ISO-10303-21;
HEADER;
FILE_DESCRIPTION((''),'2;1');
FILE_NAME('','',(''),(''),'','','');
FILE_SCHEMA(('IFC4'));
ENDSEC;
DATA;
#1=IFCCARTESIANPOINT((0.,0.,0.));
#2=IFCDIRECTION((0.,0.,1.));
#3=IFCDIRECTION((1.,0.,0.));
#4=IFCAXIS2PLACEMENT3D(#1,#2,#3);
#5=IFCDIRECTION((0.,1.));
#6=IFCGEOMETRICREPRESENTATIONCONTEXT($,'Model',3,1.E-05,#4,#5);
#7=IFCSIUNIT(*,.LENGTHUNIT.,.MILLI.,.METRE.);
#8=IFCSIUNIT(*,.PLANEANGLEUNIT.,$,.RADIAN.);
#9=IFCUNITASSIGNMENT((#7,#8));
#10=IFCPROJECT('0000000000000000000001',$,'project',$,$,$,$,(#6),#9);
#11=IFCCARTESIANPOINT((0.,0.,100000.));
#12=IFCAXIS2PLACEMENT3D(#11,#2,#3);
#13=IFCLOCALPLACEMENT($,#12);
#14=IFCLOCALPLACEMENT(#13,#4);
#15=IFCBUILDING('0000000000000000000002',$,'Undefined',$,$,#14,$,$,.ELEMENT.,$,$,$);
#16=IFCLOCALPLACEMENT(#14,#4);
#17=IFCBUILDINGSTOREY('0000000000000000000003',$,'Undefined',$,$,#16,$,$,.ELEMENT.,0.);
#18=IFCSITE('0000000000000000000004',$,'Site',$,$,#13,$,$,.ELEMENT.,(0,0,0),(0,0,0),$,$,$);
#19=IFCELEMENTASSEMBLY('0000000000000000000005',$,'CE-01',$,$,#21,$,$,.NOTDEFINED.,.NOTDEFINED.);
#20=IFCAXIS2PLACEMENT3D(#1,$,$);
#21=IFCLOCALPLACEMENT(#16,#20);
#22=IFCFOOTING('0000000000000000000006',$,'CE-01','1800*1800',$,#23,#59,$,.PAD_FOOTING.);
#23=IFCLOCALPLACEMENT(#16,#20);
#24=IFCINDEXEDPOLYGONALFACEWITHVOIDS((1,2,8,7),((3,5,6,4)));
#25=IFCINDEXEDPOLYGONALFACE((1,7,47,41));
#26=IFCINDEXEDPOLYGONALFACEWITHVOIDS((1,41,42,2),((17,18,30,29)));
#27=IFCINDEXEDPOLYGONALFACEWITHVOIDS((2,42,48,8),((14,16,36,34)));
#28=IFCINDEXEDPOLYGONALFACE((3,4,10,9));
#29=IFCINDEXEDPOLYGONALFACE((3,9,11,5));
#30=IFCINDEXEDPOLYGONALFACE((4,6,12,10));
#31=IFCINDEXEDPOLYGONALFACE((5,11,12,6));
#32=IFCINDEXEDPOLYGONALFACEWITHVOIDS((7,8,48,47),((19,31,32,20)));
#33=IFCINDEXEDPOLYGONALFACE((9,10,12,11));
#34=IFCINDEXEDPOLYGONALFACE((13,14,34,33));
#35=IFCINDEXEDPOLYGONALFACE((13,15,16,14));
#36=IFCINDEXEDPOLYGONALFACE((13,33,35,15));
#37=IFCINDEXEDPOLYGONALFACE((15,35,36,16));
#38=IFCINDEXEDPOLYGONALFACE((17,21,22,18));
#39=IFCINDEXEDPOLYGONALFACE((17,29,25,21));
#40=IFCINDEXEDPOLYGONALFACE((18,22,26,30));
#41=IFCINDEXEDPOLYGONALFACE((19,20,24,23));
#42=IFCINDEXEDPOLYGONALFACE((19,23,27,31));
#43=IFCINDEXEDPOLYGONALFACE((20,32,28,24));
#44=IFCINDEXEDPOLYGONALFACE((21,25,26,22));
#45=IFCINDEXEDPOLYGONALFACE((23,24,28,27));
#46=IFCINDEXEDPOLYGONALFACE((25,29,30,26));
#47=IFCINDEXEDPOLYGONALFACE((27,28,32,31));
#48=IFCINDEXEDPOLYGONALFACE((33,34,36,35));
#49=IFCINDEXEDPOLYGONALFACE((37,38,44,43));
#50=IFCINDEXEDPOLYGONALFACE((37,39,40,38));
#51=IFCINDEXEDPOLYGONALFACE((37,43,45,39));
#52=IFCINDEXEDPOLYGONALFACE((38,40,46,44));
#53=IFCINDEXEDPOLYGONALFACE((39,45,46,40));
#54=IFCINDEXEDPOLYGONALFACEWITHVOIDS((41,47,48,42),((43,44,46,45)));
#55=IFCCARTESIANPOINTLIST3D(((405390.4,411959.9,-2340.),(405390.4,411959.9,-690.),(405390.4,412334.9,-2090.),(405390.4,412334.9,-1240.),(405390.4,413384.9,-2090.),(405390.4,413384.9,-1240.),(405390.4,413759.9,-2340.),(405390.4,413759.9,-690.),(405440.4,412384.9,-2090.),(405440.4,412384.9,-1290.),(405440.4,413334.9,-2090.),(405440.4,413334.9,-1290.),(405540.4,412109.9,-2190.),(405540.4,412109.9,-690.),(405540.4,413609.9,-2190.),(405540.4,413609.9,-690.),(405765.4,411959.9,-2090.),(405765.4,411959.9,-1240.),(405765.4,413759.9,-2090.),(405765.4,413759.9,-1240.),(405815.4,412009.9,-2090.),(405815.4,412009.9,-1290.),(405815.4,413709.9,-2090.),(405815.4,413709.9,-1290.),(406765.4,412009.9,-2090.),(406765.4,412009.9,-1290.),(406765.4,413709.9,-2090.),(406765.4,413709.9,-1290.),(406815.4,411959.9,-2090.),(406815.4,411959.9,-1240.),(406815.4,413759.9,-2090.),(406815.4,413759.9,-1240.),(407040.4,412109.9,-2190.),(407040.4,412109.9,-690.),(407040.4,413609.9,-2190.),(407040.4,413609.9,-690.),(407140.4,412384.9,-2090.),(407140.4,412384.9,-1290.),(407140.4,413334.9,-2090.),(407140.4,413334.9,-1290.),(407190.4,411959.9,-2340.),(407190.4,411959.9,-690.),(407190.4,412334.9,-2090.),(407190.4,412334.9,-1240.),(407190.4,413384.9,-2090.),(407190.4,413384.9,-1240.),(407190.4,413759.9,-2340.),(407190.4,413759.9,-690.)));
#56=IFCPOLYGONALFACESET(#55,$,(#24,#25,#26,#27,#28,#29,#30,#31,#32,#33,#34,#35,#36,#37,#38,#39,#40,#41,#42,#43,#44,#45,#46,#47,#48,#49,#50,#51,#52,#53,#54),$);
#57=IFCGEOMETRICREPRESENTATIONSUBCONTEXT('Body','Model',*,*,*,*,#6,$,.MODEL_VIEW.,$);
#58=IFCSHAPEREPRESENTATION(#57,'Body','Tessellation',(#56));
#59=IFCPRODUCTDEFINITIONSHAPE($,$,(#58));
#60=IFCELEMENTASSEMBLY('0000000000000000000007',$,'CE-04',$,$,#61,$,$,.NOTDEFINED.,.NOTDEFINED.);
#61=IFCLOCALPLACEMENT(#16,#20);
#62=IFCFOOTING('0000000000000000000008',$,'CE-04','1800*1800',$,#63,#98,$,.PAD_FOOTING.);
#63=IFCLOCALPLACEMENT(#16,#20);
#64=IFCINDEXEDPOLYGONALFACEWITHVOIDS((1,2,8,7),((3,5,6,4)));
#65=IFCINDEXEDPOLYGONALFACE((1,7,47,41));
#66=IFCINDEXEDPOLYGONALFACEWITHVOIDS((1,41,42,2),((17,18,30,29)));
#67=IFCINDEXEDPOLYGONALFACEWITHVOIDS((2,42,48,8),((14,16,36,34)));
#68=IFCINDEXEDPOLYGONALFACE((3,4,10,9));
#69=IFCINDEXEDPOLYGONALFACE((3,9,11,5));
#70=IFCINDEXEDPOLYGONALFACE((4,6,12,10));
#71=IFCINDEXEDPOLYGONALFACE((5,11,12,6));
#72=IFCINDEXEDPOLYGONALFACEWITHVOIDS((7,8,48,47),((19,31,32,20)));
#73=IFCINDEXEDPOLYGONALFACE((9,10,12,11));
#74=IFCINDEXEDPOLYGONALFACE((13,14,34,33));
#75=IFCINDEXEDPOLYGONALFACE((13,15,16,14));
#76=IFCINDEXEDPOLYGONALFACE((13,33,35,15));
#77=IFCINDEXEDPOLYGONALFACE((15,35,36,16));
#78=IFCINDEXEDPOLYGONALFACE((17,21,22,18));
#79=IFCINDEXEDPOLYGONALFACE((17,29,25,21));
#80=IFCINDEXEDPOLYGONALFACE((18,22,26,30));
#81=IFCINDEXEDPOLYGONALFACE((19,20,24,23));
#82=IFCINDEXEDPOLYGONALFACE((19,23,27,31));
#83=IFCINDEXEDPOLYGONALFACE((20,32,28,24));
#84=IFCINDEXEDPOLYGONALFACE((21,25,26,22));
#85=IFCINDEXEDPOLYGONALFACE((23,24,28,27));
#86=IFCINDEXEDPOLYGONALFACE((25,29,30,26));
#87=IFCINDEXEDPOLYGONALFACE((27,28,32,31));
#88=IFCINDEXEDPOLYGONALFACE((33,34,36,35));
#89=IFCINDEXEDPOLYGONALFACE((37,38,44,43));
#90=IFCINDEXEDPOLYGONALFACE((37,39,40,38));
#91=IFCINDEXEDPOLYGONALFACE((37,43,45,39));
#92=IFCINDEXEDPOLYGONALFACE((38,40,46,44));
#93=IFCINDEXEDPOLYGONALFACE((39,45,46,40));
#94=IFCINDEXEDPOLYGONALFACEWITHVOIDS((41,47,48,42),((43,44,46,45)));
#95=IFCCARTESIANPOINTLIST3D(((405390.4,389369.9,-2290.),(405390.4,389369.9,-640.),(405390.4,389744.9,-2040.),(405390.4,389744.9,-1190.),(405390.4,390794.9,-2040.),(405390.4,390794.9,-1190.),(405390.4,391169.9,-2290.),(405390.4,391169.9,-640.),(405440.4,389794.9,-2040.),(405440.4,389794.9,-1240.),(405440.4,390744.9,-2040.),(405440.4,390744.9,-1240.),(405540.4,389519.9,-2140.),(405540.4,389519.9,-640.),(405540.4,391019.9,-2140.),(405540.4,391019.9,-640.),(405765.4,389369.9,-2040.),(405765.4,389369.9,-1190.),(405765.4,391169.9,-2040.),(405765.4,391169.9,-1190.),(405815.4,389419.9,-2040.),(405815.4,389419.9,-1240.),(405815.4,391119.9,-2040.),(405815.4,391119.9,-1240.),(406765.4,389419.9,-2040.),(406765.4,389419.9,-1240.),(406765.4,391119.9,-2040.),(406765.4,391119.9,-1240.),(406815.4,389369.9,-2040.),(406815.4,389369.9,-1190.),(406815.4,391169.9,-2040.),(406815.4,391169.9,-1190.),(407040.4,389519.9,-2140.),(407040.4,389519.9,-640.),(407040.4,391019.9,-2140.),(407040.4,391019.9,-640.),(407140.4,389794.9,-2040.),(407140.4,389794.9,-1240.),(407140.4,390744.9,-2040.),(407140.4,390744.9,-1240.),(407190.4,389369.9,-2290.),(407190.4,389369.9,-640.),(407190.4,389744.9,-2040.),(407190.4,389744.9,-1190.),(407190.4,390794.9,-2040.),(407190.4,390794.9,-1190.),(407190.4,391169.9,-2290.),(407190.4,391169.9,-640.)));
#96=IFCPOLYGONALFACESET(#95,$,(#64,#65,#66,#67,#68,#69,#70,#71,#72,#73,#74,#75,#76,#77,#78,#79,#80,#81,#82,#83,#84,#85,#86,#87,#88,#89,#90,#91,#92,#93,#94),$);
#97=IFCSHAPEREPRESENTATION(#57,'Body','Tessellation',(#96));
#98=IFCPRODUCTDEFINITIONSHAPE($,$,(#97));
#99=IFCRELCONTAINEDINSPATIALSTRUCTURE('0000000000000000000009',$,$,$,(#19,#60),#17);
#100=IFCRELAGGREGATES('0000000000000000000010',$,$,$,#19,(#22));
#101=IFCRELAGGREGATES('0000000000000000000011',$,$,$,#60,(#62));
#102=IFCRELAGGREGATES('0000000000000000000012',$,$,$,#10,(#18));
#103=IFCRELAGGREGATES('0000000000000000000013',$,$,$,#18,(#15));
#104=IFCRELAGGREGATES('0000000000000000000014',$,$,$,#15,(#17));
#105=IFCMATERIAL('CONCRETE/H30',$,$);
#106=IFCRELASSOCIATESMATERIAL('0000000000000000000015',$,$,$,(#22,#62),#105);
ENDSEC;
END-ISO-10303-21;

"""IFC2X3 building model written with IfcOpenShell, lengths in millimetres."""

from ifc_helpers import new_model, si_unit, direction, frame, origin_with_axes, origin_2d_with_axis, place, context, subcontext, project, spatial, polyline, rectangle, outline, extrude, boolean, material, element, aggregate, save


model = new_model("IFC2X3")

# Units and contexts
model_context = context("Model", 3, precision=1e-05, world=origin_with_axes(), true_north=direction((0.0, 1.0)))
body_context = subcontext(model_context, "Body", "Model", "MODEL_VIEW")
ifc_project = project(units=[si_unit("LENGTHUNIT", "METRE", prefix="MILLI"), si_unit("PLANEANGLEUNIT", "RADIAN")], contexts=[model_context])

# Site, building, storey
site_placement = place(None, frame((0.0, 0.0, 100000.0), z_axis=(0.0, 0.0, 1.0), x_axis=(1.0, 0.0, 0.0)))
site = spatial("IfcSite", under=ifc_project, at=site_placement, Name="Site", CompositionType="ELEMENT", RefLatitude=(0, 0, 0), RefLongitude=(0, 0, 0))
building_placement = place(site_placement, origin_with_axes())
building = spatial("IfcBuilding", under=site, at=building_placement, Name="Undefined", CompositionType="ELEMENT")
storey_placement = place(building_placement, origin_with_axes())
storey = spatial("IfcBuildingStorey", under=building, at=storey_placement, Name="Undefined", CompositionType="ELEMENT", Elevation=0.0)

# Element assemblies, footings
assembly_1_placement = place(storey_placement, origin_with_axes())
assembly_1 = element("IfcElementAssembly", 1, at=assembly_1_placement, inside=storey, Name="CE-01", AssemblyPlace="NOTDEFINED", PredefinedType="NOTDEFINED")
ifc_material_1 = material(Name="CONCRETE/H30")
footing_1_placement = place(assembly_1_placement, frame((406290.4, 412859.9, -2340.0), z_axis=(0.0, 1.0, 0.0), x_axis=(0.0, 0.0, 1.0)))
solid_1 = boolean("DIFFERENCE", boolean("DIFFERENCE", boolean("DIFFERENCE", extrude(outline(polyline([(0.0, 0.0), (1050.0, 0.0), (1050.0, 850.0), (0.0, 850.0), (0.0, 0.0)])), frame((1100.0, 900.0, -525.0), z_axis=(0.0, -1.0, 0.0), x_axis=(0.0, 0.0, 1.0)), (0.0, 0.0, 1.0), 50.0), extrude(outline(polyline([(0.0, 0.0), (70.7, 0.0), (70.7, 850.0), (0.0, 850.0), (0.0, 0.0)])), frame((1100.0, 708.6, -616.4), z_axis=(0.0, 0.707107, 0.707107), x_axis=(0.0, 0.707107, -0.707107)), (0.0, 0.0, 1.0), 200.0)), extrude(outline(polyline([(0.0, 0.0), (70.7, 0.0), (70.7, 850.0), (0.0, 850.0), (0.0, 0.0)])), frame((1100.0, 758.6, 666.4), z_axis=(0.0, 0.707107, -0.707107), x_axis=(0.0, -0.707107, -0.707107)), (0.0, 0.0, 1.0), 200.0)), extrude(outline(polyline([(0.0, 0.0), (70.7, 0.0), (70.7, 1050.0), (0.0, 1050.0), (0.0, 0.0)])), frame((1050.0, 850.0, -525.0), z_axis=(0.707107, -0.707107, 0.0), x_axis=(0.707107, 0.707107, 0.0)), (0.0, 0.0, 1.0), 200.0))
solid_2 = boolean("DIFFERENCE", boolean("DIFFERENCE", boolean("DIFFERENCE", extrude(outline(polyline([(0.0, 0.0), (1050.0, 0.0), (1050.0, 850.0), (0.0, 850.0), (0.0, 0.0)])), frame((1100.0, -525.0, -900.0), z_axis=(0.0, 0.0, 1.0), x_axis=(0.0, 1.0, 0.0)), (0.0, 0.0, 1.0), 50.0), extrude(outline(polyline([(0.0, 0.0), (70.7, 0.0), (70.7, 850.0), (0.0, 850.0), (0.0, 0.0)])), frame((1100.0, -616.4, -708.6), z_axis=(0.0, 0.707107, -0.707107), x_axis=(0.0, -0.707107, -0.707107)), (0.0, 0.0, 1.0), 200.0)), extrude(outline(polyline([(0.0, 0.0), (70.7, 0.0), (70.7, 850.0), (0.0, 850.0), (0.0, 0.0)])), frame((1100.0, 666.4, -758.6), z_axis=(0.0, -0.707107, -0.707107), x_axis=(0.0, -0.707107, 0.707107)), (0.0, 0.0, 1.0), 200.0)), extrude(outline(polyline([(0.0, 0.0), (70.7, 0.0), (70.7, 1050.0), (0.0, 1050.0), (0.0, 0.0)])), frame((1050.0, -525.0, -850.0), z_axis=(0.707107, 0.0, 0.707107), x_axis=(0.707107, 0.0, -0.707107)), (0.0, 0.0, 1.0), 200.0))
solid_3 = boolean("DIFFERENCE", boolean("DIFFERENCE", boolean("DIFFERENCE", extrude(outline(polyline([(0.0, 0.0), (1050.0, 0.0), (1050.0, 850.0), (0.0, 850.0), (0.0, 0.0)])), frame((1100.0, -525.0, 850.0), z_axis=(0.0, 0.0, 1.0), x_axis=(0.0, 1.0, 0.0)), (0.0, 0.0, 1.0), 50.0), extrude(outline(polyline([(0.0, 0.0), (70.7, 0.0), (70.7, 850.0), (0.0, 850.0), (0.0, 0.0)])), frame((1100.0, -475.0, 850.0), z_axis=(0.0, -0.707107, -0.707107), x_axis=(0.0, -0.707107, 0.707107)), (0.0, 0.0, 1.0), 200.0)), extrude(outline(polyline([(0.0, 0.0), (70.7, 0.0), (70.7, 850.0), (0.0, 850.0), (0.0, 0.0)])), frame((1100.0, 525.0, 900.0), z_axis=(0.0, 0.707107, -0.707107), x_axis=(0.0, -0.707107, -0.707107)), (0.0, 0.0, 1.0), 200.0)), extrude(outline(polyline([(0.0, 0.0), (70.7, 0.0), (70.7, 1050.0), (0.0, 1050.0), (0.0, 0.0)])), frame((1191.4, -525.0, 708.6), z_axis=(-0.707107, 0.0, 0.707107), x_axis=(0.707107, 0.0, 0.707107)), (0.0, 0.0, 1.0), 200.0))
solid_4 = boolean("DIFFERENCE", boolean("DIFFERENCE", boolean("DIFFERENCE", extrude(outline(polyline([(0.0, 0.0), (1050.0, 0.0), (1050.0, 850.0), (0.0, 850.0), (0.0, 0.0)])), frame((1100.0, -850.0, -525.0), z_axis=(0.0, -1.0, 0.0), x_axis=(0.0, 0.0, 1.0)), (0.0, 0.0, 1.0), 50.0), extrude(outline(polyline([(0.0, 0.0), (70.7, 0.0), (70.7, 850.0), (0.0, 850.0), (0.0, 0.0)])), frame((1100.0, -850.0, -475.0), z_axis=(0.0, 0.707107, -0.707107), x_axis=(0.0, -0.707107, -0.707107)), (0.0, 0.0, 1.0), 200.0)), extrude(outline(polyline([(0.0, 0.0), (70.7, 0.0), (70.7, 850.0), (0.0, 850.0), (0.0, 0.0)])), frame((1100.0, -900.0, 525.0), z_axis=(0.0, 0.707107, 0.707107), x_axis=(0.0, 0.707107, -0.707107)), (0.0, 0.0, 1.0), 200.0)), extrude(outline(polyline([(0.0, 0.0), (70.7, 0.0), (70.7, 1050.0), (0.0, 1050.0), (0.0, 0.0)])), frame((1191.4, -708.6, -525.0), z_axis=(-0.707107, -0.707107, 0.0), x_axis=(0.707107, -0.707107, 0.0)), (0.0, 0.0, 1.0), 200.0))
footing_1 = element("IfcFooting", 2, at=footing_1_placement, material=ifc_material_1, Name="CE-01", Description="1800*1800", PredefinedType="PAD_FOOTING", context=body_context, shape_type="CSG", body=[
    boolean("DIFFERENCE", boolean("DIFFERENCE", boolean("DIFFERENCE", boolean("DIFFERENCE", boolean("DIFFERENCE", extrude(rectangle(XDim=1800.0, YDim=1800.0, at=origin_2d_with_axis()), frame((1650.0, 0.0, 0.0), z_axis=(-1.0, 0.0, 0.0), x_axis=(0.0, -1.0, 0.0)), (0.0, 0.0, 1.0), 1650.0), solid_1), solid_2), solid_3), solid_4), extrude(rectangle(XDim=1500.0, YDim=1500.0, at=origin_2d_with_axis()), frame((1650.0, 0.0, 0.0), z_axis=(-1.0, 0.0, 0.0), x_axis=(0.0, -1.0, 0.0)), (0.0, 0.0, 1.0), 1500.0)),
])
aggregate(assembly_1, [footing_1])
assembly_2_placement = place(storey_placement, origin_with_axes())
assembly_2 = element("IfcElementAssembly", 3, at=assembly_2_placement, inside=storey, Name="CE-04", AssemblyPlace="NOTDEFINED", PredefinedType="NOTDEFINED")
footing_2_placement = place(assembly_2_placement, frame((406290.4, 390269.9, -2290.0), z_axis=(0.0, 1.0, 0.0), x_axis=(0.0, 0.0, 1.0)))
solid_5 = boolean("DIFFERENCE", boolean("DIFFERENCE", boolean("DIFFERENCE", extrude(outline(polyline([(0.0, 0.0), (1050.0, 0.0), (1050.0, 850.0), (0.0, 850.0), (0.0, 0.0)])), frame((1100.0, 900.0, -525.0), z_axis=(0.0, -1.0, 0.0), x_axis=(0.0, 0.0, 1.0)), (0.0, 0.0, 1.0), 50.0), extrude(outline(polyline([(0.0, 0.0), (70.7, 0.0), (70.7, 850.0), (0.0, 850.0), (0.0, 0.0)])), frame((1100.0, 708.6, -616.4), z_axis=(0.0, 0.707107, 0.707107), x_axis=(0.0, 0.707107, -0.707107)), (0.0, 0.0, 1.0), 200.0)), extrude(outline(polyline([(0.0, 0.0), (70.7, 0.0), (70.7, 850.0), (0.0, 850.0), (0.0, 0.0)])), frame((1100.0, 758.6, 666.4), z_axis=(0.0, 0.707107, -0.707107), x_axis=(0.0, -0.707107, -0.707107)), (0.0, 0.0, 1.0), 200.0)), extrude(outline(polyline([(0.0, 0.0), (70.7, 0.0), (70.7, 1050.0), (0.0, 1050.0), (0.0, 0.0)])), frame((1050.0, 850.0, -525.0), z_axis=(0.707107, -0.707107, 0.0), x_axis=(0.707107, 0.707107, 0.0)), (0.0, 0.0, 1.0), 200.0))
solid_6 = boolean("DIFFERENCE", boolean("DIFFERENCE", boolean("DIFFERENCE", extrude(outline(polyline([(0.0, 0.0), (1050.0, 0.0), (1050.0, 850.0), (0.0, 850.0), (0.0, 0.0)])), frame((1100.0, -525.0, -900.0), z_axis=(0.0, 0.0, 1.0), x_axis=(0.0, 1.0, 0.0)), (0.0, 0.0, 1.0), 50.0), extrude(outline(polyline([(0.0, 0.0), (70.7, 0.0), (70.7, 850.0), (0.0, 850.0), (0.0, 0.0)])), frame((1100.0, -616.4, -708.6), z_axis=(0.0, 0.707107, -0.707107), x_axis=(0.0, -0.707107, -0.707107)), (0.0, 0.0, 1.0), 200.0)), extrude(outline(polyline([(0.0, 0.0), (70.7, 0.0), (70.7, 850.0), (0.0, 850.0), (0.0, 0.0)])), frame((1100.0, 666.4, -758.6), z_axis=(0.0, -0.707107, -0.707107), x_axis=(0.0, -0.707107, 0.707107)), (0.0, 0.0, 1.0), 200.0)), extrude(outline(polyline([(0.0, 0.0), (70.7, 0.0), (70.7, 1050.0), (0.0, 1050.0), (0.0, 0.0)])), frame((1050.0, -525.0, -850.0), z_axis=(0.707107, 0.0, 0.707107), x_axis=(0.707107, 0.0, -0.707107)), (0.0, 0.0, 1.0), 200.0))
solid_7 = boolean("DIFFERENCE", boolean("DIFFERENCE", boolean("DIFFERENCE", extrude(outline(polyline([(0.0, 0.0), (1050.0, 0.0), (1050.0, 850.0), (0.0, 850.0), (0.0, 0.0)])), frame((1100.0, -525.0, 850.0), z_axis=(0.0, 0.0, 1.0), x_axis=(0.0, 1.0, 0.0)), (0.0, 0.0, 1.0), 50.0), extrude(outline(polyline([(0.0, 0.0), (70.7, 0.0), (70.7, 850.0), (0.0, 850.0), (0.0, 0.0)])), frame((1100.0, -475.0, 850.0), z_axis=(0.0, -0.707107, -0.707107), x_axis=(0.0, -0.707107, 0.707107)), (0.0, 0.0, 1.0), 200.0)), extrude(outline(polyline([(0.0, 0.0), (70.7, 0.0), (70.7, 850.0), (0.0, 850.0), (0.0, 0.0)])), frame((1100.0, 525.0, 900.0), z_axis=(0.0, 0.707107, -0.707107), x_axis=(0.0, -0.707107, -0.707107)), (0.0, 0.0, 1.0), 200.0)), extrude(outline(polyline([(0.0, 0.0), (70.7, 0.0), (70.7, 1050.0), (0.0, 1050.0), (0.0, 0.0)])), frame((1191.4, -525.0, 708.6), z_axis=(-0.707107, 0.0, 0.707107), x_axis=(0.707107, 0.0, 0.707107)), (0.0, 0.0, 1.0), 200.0))
solid_8 = boolean("DIFFERENCE", boolean("DIFFERENCE", boolean("DIFFERENCE", extrude(outline(polyline([(0.0, 0.0), (1050.0, 0.0), (1050.0, 850.0), (0.0, 850.0), (0.0, 0.0)])), frame((1100.0, -850.0, -525.0), z_axis=(0.0, -1.0, 0.0), x_axis=(0.0, 0.0, 1.0)), (0.0, 0.0, 1.0), 50.0), extrude(outline(polyline([(0.0, 0.0), (70.7, 0.0), (70.7, 850.0), (0.0, 850.0), (0.0, 0.0)])), frame((1100.0, -850.0, -475.0), z_axis=(0.0, 0.707107, -0.707107), x_axis=(0.0, -0.707107, -0.707107)), (0.0, 0.0, 1.0), 200.0)), extrude(outline(polyline([(0.0, 0.0), (70.7, 0.0), (70.7, 850.0), (0.0, 850.0), (0.0, 0.0)])), frame((1100.0, -900.0, 525.0), z_axis=(0.0, 0.707107, 0.707107), x_axis=(0.0, 0.707107, -0.707107)), (0.0, 0.0, 1.0), 200.0)), extrude(outline(polyline([(0.0, 0.0), (70.7, 0.0), (70.7, 1050.0), (0.0, 1050.0), (0.0, 0.0)])), frame((1191.4, -708.6, -525.0), z_axis=(-0.707107, -0.707107, 0.0), x_axis=(0.707107, -0.707107, 0.0)), (0.0, 0.0, 1.0), 200.0))
footing_2 = element("IfcFooting", 4, at=footing_2_placement, material=ifc_material_1, Name="CE-04", Description="1800*1800", PredefinedType="PAD_FOOTING", context=body_context, shape_type="CSG", body=[
    boolean("DIFFERENCE", boolean("DIFFERENCE", boolean("DIFFERENCE", boolean("DIFFERENCE", boolean("DIFFERENCE", extrude(rectangle(XDim=1800.0, YDim=1800.0, at=origin_2d_with_axis()), frame((1650.0, 0.0, 0.0), z_axis=(-1.0, 0.0, 0.0), x_axis=(0.0, -1.0, 0.0)), (0.0, 0.0, 1.0), 1650.0), solid_5), solid_6), solid_7), solid_8), extrude(rectangle(XDim=1500.0, YDim=1500.0, at=origin_2d_with_axis()), frame((1650.0, 0.0, 0.0), z_axis=(-1.0, 0.0, 0.0), x_axis=(0.0, -1.0, 0.0)), (0.0, 0.0, 1.0), 1500.0)),
])
aggregate(assembly_2, [footing_2])

save(model, "model.ifc")
